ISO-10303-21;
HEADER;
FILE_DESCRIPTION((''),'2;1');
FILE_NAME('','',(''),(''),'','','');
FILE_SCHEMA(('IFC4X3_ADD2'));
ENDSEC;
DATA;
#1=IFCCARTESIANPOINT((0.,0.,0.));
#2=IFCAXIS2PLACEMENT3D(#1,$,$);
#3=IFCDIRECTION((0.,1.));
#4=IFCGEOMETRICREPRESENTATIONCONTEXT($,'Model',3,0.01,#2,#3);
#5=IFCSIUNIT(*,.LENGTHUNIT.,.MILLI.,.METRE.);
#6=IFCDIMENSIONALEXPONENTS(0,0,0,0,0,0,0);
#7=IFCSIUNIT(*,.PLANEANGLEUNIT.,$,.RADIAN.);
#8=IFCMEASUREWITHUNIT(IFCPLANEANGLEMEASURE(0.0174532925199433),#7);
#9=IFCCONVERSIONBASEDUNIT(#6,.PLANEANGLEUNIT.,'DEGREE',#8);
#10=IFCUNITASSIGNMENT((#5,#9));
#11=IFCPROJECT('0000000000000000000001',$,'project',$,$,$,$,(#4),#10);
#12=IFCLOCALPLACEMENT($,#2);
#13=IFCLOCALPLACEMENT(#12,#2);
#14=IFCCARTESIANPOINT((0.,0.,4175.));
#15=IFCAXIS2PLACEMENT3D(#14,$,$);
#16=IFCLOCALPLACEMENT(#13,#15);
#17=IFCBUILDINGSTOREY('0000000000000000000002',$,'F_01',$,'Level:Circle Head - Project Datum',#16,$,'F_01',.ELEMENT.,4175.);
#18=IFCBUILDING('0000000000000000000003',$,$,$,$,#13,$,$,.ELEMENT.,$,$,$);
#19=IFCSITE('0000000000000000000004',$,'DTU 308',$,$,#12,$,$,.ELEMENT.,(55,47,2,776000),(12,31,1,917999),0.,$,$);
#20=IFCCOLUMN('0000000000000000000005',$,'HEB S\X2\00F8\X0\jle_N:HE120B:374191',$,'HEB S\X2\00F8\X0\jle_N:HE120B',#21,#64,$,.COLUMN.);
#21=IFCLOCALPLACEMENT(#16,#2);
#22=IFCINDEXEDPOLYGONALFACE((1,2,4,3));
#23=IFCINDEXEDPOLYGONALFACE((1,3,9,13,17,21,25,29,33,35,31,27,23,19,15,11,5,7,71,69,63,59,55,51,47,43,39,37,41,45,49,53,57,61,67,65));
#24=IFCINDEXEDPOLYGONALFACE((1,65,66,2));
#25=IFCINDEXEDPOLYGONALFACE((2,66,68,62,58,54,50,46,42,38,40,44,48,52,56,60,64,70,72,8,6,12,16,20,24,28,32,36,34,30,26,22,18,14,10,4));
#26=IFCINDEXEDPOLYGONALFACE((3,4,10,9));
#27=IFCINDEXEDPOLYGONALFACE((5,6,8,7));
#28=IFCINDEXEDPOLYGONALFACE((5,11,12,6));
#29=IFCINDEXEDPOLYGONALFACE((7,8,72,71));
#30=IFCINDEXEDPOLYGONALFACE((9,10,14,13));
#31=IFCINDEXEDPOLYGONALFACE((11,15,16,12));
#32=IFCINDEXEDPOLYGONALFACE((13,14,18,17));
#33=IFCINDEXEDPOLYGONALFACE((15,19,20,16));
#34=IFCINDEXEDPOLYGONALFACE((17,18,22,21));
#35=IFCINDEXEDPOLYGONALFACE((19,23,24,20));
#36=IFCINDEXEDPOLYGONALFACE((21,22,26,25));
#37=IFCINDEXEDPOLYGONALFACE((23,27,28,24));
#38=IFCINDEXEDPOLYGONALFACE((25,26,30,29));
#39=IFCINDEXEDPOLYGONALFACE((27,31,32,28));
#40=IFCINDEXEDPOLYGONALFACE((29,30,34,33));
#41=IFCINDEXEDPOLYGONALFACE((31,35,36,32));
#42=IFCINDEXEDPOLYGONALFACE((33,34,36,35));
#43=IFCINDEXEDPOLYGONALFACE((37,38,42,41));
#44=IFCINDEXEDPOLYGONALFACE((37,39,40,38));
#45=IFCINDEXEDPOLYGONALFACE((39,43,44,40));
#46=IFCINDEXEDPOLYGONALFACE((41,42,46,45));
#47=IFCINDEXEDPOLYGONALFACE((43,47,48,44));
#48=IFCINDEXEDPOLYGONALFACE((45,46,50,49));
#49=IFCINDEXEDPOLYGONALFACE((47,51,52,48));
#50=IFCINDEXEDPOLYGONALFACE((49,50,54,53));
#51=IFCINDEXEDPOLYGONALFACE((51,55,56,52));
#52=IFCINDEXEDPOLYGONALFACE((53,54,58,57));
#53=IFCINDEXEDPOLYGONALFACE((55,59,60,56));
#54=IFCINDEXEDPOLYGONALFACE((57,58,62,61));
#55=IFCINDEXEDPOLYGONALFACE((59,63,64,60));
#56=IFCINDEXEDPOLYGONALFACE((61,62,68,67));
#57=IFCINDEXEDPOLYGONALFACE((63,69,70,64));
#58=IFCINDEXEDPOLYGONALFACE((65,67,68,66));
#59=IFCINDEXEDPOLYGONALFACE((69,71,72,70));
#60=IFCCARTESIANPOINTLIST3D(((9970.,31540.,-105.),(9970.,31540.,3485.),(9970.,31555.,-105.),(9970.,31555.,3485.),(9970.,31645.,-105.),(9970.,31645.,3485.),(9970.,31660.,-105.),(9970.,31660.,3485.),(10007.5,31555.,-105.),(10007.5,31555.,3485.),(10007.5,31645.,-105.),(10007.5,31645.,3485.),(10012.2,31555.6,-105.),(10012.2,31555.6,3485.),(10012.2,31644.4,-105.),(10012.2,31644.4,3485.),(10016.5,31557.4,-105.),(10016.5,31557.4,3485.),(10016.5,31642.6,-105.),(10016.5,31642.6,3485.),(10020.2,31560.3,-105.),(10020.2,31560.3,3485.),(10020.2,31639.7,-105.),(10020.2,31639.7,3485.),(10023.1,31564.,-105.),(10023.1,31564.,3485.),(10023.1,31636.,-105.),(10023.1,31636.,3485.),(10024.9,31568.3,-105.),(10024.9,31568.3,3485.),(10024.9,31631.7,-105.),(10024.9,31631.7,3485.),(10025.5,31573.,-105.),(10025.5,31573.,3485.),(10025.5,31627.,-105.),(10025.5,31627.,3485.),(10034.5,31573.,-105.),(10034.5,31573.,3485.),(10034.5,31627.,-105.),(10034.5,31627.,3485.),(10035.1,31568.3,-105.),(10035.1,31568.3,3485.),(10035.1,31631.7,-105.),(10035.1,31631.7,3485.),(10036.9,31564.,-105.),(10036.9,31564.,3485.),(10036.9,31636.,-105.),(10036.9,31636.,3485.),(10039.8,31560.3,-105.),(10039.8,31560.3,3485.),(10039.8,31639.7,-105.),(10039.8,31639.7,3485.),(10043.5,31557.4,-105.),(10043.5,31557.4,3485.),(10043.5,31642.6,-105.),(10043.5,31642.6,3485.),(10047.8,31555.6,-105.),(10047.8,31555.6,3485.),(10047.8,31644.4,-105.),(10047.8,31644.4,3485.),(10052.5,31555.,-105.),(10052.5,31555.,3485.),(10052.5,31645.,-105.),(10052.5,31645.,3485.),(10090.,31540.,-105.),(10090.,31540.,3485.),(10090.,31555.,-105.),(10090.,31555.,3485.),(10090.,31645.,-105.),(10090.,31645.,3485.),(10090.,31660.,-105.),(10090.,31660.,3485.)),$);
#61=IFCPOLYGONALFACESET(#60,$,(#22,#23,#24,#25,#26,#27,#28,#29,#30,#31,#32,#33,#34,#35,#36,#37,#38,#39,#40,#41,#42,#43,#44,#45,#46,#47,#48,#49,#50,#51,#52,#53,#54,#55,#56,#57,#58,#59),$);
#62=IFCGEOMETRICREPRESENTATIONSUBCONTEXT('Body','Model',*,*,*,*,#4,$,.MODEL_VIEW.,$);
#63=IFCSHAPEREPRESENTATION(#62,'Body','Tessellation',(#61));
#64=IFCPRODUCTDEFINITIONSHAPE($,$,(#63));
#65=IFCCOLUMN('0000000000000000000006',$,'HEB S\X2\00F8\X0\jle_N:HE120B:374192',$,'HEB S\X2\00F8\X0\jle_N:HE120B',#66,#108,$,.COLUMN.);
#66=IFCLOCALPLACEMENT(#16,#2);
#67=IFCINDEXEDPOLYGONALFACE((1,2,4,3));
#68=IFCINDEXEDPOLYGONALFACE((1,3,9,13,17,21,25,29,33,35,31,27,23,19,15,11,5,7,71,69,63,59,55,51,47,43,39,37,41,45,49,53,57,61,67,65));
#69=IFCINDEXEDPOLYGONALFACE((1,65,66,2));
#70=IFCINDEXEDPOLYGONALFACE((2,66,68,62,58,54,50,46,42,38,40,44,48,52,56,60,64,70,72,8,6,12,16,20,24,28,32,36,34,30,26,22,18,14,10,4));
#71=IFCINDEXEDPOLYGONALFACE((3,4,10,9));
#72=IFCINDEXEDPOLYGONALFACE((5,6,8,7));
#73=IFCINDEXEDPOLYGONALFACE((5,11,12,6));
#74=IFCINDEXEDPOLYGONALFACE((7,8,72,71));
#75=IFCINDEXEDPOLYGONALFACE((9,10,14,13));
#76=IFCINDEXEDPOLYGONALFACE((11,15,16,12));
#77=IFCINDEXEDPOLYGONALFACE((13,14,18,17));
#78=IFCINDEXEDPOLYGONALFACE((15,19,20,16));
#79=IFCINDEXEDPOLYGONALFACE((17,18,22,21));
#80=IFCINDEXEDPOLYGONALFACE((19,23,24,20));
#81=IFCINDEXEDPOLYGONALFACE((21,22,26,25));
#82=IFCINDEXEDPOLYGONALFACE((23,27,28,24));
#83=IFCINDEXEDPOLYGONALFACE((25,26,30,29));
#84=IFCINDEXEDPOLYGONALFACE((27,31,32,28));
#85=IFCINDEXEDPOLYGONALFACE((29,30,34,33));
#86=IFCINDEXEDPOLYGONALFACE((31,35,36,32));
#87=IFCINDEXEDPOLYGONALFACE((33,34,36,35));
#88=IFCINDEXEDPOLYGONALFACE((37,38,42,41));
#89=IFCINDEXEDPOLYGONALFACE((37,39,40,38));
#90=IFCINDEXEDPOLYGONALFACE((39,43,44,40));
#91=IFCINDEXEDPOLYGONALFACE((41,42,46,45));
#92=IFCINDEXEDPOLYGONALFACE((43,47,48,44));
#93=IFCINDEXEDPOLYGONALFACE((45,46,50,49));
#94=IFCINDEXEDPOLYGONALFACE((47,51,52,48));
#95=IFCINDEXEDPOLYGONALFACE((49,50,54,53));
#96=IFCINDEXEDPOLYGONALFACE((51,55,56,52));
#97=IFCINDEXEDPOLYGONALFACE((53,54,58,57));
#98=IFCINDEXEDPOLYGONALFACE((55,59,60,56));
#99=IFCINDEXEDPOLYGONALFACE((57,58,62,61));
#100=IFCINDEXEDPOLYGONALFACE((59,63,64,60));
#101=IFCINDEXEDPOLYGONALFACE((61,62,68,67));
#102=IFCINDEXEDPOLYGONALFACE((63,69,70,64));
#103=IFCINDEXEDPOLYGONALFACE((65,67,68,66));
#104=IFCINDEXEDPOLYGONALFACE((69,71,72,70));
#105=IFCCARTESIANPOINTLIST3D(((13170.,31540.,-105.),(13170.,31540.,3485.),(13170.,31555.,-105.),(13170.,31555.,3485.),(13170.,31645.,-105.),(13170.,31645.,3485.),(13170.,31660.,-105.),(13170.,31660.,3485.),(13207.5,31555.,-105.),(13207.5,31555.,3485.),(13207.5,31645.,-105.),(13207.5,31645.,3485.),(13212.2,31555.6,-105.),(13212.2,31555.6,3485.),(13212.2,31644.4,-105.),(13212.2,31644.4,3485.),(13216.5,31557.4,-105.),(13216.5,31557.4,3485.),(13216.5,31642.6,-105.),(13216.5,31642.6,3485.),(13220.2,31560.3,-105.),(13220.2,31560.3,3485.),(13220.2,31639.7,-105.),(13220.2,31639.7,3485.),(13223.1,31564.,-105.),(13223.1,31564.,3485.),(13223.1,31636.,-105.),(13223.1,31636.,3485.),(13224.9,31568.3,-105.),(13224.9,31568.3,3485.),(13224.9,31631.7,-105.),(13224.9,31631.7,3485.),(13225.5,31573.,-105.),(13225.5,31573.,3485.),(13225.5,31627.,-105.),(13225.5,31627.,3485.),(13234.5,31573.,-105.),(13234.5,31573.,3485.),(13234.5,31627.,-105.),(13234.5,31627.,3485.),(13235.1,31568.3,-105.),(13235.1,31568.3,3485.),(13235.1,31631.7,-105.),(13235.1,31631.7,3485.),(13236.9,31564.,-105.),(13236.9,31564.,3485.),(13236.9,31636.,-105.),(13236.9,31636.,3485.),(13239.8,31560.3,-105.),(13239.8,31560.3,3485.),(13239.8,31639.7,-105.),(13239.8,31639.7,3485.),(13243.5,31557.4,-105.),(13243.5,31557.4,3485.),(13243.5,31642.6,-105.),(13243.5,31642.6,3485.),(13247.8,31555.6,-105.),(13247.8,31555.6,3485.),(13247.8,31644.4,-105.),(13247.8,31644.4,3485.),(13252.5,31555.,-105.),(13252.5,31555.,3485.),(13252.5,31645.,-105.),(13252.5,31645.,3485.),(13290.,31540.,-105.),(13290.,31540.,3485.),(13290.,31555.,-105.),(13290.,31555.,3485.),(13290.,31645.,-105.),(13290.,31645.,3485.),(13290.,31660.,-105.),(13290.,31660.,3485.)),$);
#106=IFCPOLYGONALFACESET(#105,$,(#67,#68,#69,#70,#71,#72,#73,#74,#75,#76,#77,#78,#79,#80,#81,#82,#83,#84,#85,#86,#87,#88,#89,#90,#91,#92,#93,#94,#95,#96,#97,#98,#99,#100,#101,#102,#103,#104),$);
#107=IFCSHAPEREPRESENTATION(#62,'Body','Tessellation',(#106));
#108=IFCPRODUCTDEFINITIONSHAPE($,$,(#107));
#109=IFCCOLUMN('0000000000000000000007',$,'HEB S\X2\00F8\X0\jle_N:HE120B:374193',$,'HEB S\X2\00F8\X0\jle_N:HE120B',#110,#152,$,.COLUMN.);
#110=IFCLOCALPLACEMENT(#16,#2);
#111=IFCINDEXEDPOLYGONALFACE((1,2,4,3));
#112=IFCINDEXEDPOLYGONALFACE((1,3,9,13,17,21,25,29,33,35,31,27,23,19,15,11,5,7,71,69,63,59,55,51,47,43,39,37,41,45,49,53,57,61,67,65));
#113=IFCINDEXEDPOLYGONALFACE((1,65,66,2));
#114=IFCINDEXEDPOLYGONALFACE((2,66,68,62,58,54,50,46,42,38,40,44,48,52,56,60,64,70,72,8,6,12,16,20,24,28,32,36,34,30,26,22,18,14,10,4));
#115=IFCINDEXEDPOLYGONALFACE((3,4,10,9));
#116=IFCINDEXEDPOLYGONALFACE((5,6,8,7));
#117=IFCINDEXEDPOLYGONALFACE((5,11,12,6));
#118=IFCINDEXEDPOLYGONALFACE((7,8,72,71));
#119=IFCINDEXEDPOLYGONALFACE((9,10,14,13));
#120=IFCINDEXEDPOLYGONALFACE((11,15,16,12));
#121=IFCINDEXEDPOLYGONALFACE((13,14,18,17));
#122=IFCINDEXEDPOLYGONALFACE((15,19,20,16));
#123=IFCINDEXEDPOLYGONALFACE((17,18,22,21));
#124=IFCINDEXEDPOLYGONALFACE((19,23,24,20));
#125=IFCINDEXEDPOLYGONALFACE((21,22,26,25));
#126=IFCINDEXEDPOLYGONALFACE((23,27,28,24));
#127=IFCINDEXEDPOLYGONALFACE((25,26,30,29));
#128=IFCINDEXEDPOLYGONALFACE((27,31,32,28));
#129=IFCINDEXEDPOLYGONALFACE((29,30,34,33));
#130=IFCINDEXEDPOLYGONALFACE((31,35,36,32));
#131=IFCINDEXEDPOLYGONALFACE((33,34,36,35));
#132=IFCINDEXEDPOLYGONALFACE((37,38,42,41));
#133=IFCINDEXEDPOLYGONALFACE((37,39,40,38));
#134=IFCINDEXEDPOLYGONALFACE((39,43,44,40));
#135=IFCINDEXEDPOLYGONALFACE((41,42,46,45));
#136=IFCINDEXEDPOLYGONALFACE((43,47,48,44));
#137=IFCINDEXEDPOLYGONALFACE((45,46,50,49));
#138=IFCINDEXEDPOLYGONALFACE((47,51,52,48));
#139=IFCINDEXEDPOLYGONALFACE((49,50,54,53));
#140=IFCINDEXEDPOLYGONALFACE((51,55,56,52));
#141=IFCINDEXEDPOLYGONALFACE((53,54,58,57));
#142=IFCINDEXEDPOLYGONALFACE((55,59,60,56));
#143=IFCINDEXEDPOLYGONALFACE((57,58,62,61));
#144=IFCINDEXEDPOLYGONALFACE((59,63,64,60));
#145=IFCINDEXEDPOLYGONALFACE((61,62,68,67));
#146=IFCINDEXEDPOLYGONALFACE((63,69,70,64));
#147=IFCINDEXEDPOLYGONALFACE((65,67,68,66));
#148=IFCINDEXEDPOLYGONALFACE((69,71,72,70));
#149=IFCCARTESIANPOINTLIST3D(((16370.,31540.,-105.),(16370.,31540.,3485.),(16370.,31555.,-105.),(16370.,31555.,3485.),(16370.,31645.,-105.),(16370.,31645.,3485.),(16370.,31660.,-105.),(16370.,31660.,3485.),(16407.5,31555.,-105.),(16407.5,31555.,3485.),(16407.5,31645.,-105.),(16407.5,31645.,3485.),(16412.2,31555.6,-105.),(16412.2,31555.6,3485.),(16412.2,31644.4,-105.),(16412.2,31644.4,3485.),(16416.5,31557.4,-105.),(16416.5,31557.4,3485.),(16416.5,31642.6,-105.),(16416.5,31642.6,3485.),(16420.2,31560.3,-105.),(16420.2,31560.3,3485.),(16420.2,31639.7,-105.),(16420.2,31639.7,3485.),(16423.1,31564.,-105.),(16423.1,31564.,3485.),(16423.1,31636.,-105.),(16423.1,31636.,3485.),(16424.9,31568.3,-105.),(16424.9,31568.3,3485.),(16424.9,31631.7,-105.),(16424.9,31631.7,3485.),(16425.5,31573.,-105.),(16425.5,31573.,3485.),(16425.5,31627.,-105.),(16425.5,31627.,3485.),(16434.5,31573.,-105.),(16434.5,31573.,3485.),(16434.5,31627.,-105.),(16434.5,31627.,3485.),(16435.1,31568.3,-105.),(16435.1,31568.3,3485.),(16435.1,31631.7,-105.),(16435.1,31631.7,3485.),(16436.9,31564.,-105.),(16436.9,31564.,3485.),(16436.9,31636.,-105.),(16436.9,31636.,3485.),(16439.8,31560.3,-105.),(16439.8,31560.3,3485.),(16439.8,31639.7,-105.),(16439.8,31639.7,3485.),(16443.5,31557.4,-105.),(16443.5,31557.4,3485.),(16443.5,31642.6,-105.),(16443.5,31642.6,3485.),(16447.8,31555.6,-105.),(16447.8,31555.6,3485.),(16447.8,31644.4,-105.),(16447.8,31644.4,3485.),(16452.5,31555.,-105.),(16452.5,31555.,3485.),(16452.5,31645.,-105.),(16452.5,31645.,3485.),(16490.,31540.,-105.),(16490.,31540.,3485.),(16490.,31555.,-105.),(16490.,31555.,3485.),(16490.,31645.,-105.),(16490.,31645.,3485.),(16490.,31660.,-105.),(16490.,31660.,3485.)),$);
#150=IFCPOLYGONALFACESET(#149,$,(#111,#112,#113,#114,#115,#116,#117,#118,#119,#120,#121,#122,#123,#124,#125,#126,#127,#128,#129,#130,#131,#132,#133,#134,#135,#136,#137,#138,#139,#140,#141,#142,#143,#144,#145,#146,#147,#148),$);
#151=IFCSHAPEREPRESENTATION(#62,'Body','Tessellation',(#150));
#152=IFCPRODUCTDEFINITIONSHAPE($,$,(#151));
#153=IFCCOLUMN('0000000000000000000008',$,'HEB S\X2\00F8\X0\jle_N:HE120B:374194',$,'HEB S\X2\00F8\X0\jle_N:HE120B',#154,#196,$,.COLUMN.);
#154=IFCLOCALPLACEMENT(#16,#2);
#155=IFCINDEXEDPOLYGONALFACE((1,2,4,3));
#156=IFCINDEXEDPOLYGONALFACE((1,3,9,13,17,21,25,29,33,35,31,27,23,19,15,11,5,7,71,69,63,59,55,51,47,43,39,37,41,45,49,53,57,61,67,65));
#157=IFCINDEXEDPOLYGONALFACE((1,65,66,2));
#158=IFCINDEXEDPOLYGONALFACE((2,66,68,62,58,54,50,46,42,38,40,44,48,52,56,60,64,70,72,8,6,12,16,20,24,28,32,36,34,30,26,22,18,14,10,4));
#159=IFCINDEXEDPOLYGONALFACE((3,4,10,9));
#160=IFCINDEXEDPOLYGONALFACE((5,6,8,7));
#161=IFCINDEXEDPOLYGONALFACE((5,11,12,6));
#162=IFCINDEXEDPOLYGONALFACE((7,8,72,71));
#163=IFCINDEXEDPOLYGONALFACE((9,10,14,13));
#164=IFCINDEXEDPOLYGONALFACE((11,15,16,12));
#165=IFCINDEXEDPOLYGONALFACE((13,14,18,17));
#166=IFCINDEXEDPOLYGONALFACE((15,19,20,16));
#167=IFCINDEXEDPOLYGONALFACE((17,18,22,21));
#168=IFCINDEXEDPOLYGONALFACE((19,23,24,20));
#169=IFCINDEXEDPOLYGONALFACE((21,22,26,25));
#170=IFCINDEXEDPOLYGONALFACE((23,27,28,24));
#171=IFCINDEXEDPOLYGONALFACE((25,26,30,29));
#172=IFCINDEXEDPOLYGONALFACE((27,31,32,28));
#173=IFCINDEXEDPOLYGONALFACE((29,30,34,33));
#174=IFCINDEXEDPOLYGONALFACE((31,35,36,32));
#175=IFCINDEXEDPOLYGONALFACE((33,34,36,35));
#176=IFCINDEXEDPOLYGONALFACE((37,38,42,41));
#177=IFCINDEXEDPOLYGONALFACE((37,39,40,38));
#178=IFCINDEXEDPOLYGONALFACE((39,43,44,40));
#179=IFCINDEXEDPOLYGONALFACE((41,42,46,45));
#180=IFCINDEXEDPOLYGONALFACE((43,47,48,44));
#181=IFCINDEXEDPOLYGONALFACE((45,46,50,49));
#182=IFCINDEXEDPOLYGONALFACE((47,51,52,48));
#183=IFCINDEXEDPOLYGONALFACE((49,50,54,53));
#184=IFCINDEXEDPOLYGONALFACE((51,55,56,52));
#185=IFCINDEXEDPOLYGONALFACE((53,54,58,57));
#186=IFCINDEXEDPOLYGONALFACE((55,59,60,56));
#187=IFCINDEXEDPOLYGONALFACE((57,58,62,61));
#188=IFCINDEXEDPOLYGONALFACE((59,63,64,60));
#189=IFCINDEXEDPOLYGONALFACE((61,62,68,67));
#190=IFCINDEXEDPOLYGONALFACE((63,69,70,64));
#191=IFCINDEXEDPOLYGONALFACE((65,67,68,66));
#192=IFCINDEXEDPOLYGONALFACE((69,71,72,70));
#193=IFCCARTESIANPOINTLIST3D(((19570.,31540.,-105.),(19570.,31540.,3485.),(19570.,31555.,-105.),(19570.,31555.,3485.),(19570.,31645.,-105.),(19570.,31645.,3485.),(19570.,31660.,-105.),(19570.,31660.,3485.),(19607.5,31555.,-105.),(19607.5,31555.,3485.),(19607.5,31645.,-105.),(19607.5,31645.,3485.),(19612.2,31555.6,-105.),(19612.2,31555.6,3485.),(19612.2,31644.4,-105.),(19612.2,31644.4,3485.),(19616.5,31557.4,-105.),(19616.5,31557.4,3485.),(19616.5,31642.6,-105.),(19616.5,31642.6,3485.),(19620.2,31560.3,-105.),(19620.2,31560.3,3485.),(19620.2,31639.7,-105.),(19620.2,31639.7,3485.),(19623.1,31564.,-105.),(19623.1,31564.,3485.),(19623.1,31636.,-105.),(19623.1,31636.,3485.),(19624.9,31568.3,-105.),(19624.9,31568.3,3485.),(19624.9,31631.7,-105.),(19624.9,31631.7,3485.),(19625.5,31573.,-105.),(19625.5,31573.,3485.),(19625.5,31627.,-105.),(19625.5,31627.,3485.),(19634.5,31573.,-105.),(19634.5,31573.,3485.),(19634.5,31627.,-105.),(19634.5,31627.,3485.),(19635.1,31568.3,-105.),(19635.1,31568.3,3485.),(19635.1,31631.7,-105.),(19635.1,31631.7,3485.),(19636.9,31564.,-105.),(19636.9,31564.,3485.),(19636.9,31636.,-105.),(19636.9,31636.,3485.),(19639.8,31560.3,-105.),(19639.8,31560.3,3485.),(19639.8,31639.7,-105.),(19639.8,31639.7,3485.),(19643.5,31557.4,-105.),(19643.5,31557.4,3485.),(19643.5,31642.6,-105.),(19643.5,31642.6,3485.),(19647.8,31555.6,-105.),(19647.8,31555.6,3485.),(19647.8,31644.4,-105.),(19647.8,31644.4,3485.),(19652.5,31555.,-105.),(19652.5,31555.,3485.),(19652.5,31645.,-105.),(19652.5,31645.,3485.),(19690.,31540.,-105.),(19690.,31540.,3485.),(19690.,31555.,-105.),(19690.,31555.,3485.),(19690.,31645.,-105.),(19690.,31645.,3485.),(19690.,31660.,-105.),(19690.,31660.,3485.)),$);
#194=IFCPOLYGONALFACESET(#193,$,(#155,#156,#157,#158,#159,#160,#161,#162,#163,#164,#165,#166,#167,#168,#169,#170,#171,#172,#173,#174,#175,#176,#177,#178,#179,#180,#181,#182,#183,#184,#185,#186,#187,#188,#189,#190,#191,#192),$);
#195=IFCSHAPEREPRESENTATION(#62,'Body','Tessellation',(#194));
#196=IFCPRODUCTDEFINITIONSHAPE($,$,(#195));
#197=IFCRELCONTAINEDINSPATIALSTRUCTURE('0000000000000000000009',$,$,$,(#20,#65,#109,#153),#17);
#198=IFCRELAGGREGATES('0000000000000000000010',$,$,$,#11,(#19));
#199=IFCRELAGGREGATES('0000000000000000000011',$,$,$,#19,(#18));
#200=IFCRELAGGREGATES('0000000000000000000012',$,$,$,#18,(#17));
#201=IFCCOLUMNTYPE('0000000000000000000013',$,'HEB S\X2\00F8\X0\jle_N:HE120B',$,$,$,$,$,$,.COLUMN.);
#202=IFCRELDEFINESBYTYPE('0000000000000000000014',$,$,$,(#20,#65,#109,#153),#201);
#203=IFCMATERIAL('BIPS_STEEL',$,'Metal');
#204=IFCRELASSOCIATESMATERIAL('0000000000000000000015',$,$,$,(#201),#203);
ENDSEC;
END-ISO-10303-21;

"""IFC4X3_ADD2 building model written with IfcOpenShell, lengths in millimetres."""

from ifc_helpers import new_model, entity, si_unit, converted_unit, direction, frame, frame_2d, origin, place, context, subcontext, project, spatial, i_section, extrude, source, transform, mapped, material, material_profile, profile_set, type_object, type_shapes, element, save


model = new_model("IFC4X3_ADD2")

# Units and contexts
model_context = context("Model", 3, precision=0.01, world=origin(), true_north=direction((0.0, 1.0)))
body_context = subcontext(model_context, "Body", "Model", "MODEL_VIEW")
ifc_project = project(units=[si_unit("LENGTHUNIT", "METRE", prefix="MILLI"), converted_unit("PLANEANGLEUNIT", "DEGREE", entity("IfcPlaneAngleMeasure", 0.0174532925199433), si_unit("PLANEANGLEUNIT", "RADIAN"), dimensions=[0, 0, 0, 0, 0, 0, 0])], contexts=[model_context])

# Site, building, storey
site_placement = place(None, origin())
site = spatial("IfcSite", under=ifc_project, at=site_placement, Name="DTU 308", CompositionType="ELEMENT", RefLatitude=(55, 47, 2, 776000), RefLongitude=(12, 31, 1, 917999), RefElevation=0.0)
building_placement = place(site_placement, origin())
building = spatial("IfcBuilding", under=site, at=building_placement, CompositionType="ELEMENT")
storey_placement = place(building_placement, frame((0.0, 0.0, 4175.0)))
storey = spatial("IfcBuildingStorey", under=building, at=storey_placement, Name="F_01", ObjectType="Level:Circle Head - Project Datum", LongName="F_01", CompositionType="ELEMENT", Elevation=4175.0)

# Columns
ifc_material_1 = material(Name="BIPS_STEEL", Category="Metal")
ifc_material_profile_1 = material_profile(ifc_material_1, i_section(OverallWidth=120.0, OverallDepth=120.0, WebThickness=9.0, FlangeThickness=15.0, FilletRadius=18.0, at=frame_2d((0.0, 0.0), x_axis=(1.0, 0.0))), Name="HE120B")
ifc_profile_set_1 = profile_set([ifc_material_profile_1], Name="HE120B")
column_type_1 = type_object("IfcColumnType", Name="HEB Søjle_N:HE120B", PredefinedType="COLUMN", material=ifc_profile_set_1)
shared_shape_1 = source(origin(), body_context, "Body", "SweptSolid", [
    extrude(i_section(OverallWidth=120.0, OverallDepth=120.0, WebThickness=9.0, FlangeThickness=15.0, FilletRadius=18.0, at=frame_2d((0.0, 0.0), x_axis=(1.0, 0.0))), frame((0.0, 0.0, 4070.0), z_axis=(0.0, 0.0, 1.0), x_axis=(-1.0, 0.0, 0.0)), (0.0, 0.0, 1.0), 3590.0),
])
type_shapes(column_type_1, [shared_shape_1])
for number, where, name in (
    (1, (10030.0, 31600.0, -4175.0), "HEB Søjle_N:HE120B:374191"),
    (2, (13230.0, 31600.0, -4175.0), "HEB Søjle_N:HE120B:374192"),
    (3, (16430.0, 31600.0, -4175.0), "HEB Søjle_N:HE120B:374193"),
    (4, (19630.0, 31600.0, -4175.0), "HEB Søjle_N:HE120B:374194"),
):
    element("IfcColumn", number, at=place(storey_placement, frame(where)), inside=storey, type_object=column_type_1, Name=name, ObjectType="HEB Søjle_N:HE120B", PredefinedType="COLUMN", context=body_context, shape_type="MappedRepresentation", body=[
        mapped(shared_shape_1, transform((0.0, 0.0, 0.0), scale=1.0)),
    ])

save(model, "model.ifc")
